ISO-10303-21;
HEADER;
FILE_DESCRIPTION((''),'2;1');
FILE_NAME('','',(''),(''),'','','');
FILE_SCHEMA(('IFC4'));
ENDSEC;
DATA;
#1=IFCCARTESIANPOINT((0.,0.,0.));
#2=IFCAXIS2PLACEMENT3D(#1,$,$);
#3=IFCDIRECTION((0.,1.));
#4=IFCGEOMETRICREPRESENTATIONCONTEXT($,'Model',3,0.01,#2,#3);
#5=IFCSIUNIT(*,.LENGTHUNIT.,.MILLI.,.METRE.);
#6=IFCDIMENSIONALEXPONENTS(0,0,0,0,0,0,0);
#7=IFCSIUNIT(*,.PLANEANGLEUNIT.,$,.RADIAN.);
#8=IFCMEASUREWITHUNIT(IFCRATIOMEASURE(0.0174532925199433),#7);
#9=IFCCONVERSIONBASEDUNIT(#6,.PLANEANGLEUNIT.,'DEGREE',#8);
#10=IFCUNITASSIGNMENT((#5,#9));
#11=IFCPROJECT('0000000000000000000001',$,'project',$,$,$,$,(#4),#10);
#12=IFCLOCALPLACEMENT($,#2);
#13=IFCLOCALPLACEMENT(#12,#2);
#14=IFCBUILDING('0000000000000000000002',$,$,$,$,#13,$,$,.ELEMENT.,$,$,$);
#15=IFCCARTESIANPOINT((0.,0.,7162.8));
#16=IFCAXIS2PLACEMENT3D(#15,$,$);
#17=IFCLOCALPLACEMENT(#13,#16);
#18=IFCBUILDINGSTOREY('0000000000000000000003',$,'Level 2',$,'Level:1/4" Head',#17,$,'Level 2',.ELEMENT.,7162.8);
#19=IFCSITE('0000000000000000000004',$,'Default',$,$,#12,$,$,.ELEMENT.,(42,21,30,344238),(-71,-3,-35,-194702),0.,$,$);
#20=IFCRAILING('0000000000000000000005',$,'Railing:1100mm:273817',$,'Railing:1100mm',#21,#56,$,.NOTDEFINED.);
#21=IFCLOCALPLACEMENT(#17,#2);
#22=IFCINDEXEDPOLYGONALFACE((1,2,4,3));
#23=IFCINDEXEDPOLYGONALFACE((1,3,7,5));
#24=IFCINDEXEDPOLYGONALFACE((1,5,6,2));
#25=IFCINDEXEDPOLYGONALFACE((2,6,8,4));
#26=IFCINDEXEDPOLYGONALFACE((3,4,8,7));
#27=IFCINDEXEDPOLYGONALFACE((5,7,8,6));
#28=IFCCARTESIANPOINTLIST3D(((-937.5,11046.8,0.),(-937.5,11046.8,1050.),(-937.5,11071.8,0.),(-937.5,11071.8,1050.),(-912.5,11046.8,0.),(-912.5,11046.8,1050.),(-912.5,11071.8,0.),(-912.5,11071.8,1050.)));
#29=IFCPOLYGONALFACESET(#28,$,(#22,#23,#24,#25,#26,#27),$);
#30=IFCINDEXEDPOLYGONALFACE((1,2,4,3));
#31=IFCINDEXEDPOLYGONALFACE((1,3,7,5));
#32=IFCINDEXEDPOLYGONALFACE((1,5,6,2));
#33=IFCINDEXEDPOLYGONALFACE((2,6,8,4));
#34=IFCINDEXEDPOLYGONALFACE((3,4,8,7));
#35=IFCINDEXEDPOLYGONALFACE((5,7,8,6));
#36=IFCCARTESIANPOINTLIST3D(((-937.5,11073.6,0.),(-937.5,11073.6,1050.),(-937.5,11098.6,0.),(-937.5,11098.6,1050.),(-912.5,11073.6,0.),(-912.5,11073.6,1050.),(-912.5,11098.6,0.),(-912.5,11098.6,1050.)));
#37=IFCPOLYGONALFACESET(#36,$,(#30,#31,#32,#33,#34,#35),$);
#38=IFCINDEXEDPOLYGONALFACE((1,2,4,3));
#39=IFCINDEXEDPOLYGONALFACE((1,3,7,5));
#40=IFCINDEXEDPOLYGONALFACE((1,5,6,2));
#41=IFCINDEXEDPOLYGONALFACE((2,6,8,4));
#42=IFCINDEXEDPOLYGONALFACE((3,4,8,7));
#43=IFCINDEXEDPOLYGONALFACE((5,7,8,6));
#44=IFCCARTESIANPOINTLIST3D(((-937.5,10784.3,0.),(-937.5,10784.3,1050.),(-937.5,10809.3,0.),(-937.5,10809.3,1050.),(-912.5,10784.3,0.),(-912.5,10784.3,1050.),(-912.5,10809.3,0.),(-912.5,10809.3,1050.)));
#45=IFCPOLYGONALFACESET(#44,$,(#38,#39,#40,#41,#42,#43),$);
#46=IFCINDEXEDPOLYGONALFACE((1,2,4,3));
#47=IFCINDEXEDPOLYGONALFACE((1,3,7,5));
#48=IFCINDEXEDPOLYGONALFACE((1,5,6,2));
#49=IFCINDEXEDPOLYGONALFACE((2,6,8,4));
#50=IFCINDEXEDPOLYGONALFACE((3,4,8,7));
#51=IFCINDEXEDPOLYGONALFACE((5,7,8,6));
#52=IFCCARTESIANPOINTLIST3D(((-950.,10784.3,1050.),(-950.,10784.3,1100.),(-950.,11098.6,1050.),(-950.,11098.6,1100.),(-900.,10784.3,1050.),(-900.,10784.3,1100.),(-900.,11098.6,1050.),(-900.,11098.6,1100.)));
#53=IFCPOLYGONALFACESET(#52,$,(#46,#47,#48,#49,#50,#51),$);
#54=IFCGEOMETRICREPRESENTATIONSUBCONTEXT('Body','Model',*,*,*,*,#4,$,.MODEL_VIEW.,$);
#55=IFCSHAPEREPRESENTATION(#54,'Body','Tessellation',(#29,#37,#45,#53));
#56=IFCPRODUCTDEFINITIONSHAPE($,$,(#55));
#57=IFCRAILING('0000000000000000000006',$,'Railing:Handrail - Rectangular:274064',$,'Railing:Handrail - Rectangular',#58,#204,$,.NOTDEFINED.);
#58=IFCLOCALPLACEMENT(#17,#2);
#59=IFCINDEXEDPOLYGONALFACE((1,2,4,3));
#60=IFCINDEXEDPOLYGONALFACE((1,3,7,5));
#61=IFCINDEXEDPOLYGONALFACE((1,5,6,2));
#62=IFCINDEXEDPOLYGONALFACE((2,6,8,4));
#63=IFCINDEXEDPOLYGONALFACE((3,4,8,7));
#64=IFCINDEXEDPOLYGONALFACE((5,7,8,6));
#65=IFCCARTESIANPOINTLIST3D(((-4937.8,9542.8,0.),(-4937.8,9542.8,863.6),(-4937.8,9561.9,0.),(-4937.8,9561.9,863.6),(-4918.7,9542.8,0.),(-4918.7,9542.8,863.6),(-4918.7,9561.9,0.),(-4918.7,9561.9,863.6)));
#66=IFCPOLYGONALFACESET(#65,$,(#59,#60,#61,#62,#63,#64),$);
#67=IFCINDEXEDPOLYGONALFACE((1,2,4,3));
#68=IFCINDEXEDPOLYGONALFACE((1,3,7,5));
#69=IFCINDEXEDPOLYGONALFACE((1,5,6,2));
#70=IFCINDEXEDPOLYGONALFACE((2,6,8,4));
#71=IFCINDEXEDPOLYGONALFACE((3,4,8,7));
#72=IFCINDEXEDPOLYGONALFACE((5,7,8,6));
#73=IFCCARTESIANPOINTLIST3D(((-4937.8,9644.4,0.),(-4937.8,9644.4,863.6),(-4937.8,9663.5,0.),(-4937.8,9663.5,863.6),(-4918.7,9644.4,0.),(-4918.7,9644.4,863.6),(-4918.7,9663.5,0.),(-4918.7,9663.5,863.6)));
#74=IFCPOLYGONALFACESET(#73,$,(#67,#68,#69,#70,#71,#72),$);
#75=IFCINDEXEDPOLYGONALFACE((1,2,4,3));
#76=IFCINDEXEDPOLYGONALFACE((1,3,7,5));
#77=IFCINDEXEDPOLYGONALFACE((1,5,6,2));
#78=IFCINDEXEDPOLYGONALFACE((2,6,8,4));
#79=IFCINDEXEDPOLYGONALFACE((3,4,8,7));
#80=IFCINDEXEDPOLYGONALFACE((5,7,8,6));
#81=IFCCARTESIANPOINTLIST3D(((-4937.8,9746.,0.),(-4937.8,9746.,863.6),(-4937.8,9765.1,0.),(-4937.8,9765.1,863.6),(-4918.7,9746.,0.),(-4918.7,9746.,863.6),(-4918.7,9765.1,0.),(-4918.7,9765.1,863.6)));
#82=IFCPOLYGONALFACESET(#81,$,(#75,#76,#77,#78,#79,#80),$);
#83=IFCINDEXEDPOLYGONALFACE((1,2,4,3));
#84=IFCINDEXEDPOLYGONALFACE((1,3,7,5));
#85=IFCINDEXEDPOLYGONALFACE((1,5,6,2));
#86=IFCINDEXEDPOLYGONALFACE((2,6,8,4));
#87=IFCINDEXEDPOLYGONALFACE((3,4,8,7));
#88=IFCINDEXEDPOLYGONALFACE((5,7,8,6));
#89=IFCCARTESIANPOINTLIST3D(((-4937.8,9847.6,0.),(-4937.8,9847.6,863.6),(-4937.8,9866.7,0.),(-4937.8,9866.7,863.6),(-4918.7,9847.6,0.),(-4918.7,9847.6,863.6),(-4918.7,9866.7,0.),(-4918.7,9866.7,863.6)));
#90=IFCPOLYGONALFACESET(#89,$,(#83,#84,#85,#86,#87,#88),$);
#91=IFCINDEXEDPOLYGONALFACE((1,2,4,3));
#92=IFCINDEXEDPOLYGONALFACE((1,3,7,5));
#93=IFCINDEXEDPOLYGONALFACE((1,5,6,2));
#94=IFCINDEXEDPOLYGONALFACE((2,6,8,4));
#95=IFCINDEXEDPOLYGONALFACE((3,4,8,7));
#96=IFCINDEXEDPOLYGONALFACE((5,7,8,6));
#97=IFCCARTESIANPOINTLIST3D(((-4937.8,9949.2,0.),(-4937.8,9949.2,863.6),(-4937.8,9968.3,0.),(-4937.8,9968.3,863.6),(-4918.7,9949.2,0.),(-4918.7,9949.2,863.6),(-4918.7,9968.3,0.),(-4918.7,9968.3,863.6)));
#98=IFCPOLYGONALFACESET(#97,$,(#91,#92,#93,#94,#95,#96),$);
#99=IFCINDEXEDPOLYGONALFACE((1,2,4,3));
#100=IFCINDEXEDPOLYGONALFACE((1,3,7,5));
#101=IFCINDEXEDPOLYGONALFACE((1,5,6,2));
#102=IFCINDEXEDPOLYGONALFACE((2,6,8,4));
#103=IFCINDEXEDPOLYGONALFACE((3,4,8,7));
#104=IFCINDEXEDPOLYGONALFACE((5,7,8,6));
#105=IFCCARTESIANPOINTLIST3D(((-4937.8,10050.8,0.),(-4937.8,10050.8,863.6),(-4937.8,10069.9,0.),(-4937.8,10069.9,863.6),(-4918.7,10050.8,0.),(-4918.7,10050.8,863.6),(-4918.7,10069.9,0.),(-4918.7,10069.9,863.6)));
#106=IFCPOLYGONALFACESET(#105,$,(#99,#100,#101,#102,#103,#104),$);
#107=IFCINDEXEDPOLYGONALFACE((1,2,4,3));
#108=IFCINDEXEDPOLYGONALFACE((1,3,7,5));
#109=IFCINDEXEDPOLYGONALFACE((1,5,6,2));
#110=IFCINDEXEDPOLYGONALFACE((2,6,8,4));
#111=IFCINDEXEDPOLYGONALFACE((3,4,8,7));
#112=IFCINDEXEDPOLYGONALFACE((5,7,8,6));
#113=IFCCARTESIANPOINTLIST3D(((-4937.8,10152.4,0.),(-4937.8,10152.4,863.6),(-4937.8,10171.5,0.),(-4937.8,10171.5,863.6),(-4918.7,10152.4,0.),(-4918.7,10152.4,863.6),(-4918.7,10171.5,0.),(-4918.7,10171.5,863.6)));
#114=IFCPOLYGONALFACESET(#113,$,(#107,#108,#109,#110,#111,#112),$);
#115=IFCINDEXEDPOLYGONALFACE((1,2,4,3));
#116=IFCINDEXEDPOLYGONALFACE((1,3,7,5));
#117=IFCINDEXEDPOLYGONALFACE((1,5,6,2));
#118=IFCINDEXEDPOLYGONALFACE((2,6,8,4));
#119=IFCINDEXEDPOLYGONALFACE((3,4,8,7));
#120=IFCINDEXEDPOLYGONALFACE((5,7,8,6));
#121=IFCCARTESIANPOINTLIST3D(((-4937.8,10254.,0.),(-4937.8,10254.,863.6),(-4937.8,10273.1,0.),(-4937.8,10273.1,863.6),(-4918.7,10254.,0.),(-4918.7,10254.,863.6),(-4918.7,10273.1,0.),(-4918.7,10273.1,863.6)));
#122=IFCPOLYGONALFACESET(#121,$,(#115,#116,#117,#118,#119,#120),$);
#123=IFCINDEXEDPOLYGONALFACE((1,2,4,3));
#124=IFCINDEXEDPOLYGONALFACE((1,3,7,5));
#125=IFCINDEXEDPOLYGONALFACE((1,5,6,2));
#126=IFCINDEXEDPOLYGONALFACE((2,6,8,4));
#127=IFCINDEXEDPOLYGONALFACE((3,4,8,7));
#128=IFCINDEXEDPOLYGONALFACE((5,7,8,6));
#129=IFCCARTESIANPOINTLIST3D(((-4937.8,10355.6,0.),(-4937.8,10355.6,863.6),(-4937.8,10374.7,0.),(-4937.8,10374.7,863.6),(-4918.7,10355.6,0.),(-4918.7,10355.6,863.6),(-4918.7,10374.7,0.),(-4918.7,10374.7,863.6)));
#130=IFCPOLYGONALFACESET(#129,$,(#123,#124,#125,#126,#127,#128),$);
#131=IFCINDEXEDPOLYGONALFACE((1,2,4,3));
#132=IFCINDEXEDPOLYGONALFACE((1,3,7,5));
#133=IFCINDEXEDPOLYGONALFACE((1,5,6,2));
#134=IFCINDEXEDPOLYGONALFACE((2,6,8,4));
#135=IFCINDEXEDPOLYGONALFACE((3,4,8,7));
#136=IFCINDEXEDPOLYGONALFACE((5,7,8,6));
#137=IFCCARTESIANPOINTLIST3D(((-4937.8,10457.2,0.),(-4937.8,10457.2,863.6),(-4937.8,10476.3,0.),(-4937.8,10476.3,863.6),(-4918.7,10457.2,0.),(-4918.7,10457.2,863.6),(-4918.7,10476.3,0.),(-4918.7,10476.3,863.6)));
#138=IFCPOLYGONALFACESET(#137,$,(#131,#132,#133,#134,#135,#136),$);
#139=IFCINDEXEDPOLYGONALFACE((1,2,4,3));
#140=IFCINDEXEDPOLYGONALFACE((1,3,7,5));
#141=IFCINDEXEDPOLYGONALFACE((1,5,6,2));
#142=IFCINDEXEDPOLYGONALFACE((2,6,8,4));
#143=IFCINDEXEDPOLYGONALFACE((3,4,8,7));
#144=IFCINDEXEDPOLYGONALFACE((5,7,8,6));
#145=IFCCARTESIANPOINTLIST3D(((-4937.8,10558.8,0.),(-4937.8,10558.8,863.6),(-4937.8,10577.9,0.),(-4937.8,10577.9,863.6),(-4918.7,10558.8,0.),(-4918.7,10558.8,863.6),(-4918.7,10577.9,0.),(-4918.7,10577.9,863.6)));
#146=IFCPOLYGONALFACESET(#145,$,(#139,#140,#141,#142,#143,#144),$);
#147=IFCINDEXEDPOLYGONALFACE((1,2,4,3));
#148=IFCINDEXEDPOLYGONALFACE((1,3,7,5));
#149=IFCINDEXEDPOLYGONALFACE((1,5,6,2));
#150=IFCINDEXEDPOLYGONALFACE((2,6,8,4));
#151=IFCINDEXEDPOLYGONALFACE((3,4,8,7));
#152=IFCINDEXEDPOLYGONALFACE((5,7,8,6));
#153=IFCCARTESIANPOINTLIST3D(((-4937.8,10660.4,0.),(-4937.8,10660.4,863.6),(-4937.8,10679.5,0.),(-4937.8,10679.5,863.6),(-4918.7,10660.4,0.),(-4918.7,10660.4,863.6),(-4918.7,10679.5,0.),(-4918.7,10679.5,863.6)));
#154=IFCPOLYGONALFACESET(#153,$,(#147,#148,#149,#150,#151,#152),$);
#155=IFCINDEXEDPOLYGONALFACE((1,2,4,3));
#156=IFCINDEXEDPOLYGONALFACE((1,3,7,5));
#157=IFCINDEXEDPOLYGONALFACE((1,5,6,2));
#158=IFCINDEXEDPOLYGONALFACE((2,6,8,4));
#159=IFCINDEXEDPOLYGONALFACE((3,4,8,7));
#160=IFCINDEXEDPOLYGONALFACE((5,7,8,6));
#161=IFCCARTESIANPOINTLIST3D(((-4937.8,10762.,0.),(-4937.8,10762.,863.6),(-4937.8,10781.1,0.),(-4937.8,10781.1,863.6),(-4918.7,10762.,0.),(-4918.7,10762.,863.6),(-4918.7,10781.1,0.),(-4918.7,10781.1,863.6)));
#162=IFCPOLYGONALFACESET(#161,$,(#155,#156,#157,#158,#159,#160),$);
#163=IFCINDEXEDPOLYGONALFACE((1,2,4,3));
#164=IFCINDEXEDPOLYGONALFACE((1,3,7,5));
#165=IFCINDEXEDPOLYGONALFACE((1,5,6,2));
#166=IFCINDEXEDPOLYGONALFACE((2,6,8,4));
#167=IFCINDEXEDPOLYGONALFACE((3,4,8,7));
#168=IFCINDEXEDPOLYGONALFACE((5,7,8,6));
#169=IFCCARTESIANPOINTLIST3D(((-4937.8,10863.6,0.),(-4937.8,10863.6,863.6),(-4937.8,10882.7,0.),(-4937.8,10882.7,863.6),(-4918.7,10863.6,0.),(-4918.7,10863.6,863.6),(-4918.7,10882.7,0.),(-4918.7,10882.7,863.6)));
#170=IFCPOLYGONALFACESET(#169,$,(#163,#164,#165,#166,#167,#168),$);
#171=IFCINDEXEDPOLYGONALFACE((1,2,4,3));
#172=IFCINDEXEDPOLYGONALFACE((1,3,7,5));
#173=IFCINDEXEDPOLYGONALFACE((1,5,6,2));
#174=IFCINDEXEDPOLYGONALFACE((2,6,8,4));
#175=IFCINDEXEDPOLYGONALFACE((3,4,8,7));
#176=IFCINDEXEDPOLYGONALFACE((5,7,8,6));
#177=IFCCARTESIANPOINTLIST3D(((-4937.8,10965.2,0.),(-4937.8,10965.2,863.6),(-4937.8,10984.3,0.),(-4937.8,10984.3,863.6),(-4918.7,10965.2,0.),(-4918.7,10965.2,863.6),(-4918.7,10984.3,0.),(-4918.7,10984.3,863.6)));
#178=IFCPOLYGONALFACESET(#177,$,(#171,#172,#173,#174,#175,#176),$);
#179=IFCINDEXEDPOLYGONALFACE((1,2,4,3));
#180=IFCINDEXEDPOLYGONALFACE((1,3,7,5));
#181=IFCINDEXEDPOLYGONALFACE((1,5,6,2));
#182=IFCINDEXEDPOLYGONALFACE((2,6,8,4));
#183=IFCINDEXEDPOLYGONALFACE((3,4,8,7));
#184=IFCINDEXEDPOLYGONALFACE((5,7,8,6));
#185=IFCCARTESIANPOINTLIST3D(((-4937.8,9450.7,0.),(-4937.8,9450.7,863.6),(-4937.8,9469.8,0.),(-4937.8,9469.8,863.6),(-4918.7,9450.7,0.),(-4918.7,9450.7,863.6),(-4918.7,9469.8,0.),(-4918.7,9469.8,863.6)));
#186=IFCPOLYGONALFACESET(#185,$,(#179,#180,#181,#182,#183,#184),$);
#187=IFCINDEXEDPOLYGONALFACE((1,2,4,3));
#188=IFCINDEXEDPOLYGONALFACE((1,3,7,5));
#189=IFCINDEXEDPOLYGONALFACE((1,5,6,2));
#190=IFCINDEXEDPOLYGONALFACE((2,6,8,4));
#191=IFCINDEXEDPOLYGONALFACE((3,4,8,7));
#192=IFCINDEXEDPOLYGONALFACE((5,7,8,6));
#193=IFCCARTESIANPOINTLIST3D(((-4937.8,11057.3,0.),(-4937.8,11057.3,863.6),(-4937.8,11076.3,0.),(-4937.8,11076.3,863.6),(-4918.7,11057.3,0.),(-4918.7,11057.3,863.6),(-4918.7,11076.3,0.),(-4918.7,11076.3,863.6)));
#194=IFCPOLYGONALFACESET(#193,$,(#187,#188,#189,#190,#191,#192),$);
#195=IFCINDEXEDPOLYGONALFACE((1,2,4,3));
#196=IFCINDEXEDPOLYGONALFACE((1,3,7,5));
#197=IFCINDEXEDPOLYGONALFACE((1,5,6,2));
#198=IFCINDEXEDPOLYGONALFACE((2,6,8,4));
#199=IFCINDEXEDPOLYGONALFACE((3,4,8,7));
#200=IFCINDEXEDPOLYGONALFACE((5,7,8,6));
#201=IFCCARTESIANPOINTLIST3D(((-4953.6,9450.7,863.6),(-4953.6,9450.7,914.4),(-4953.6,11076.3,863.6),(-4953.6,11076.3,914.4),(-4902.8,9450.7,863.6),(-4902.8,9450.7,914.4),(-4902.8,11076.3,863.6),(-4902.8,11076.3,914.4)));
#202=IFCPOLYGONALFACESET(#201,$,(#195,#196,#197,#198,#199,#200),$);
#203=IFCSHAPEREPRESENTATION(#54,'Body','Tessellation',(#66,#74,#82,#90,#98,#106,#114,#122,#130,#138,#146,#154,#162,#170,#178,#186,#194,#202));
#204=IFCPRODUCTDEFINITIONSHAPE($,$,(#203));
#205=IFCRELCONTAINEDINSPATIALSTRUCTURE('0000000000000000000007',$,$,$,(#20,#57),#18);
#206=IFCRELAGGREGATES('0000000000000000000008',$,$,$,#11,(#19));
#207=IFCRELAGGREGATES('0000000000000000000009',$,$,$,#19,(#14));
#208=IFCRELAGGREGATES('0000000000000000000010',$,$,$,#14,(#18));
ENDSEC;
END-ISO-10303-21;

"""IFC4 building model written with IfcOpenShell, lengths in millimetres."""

from ifc_helpers import new_model, entity, si_unit, converted_unit, direction, frame, origin, place, context, subcontext, project, spatial, indexed_curve, outline, extrude, element, save


model = new_model("IFC4")

# Units and contexts
model_context = context("Model", 3, precision=0.01, world=origin(), true_north=direction((0.0, 1.0)))
body_context = subcontext(model_context, "Body", "Model", "MODEL_VIEW")
ifc_project = project(units=[si_unit("LENGTHUNIT", "METRE", prefix="MILLI"), converted_unit("PLANEANGLEUNIT", "DEGREE", entity("IfcRatioMeasure", 0.0174532925199433), si_unit("PLANEANGLEUNIT", "RADIAN"), dimensions=[0, 0, 0, 0, 0, 0, 0])], contexts=[model_context])

# Site, building, storey
site_placement = place(None, origin())
site = spatial("IfcSite", under=ifc_project, at=site_placement, Name="Default", CompositionType="ELEMENT", RefLatitude=(42, 21, 30, 344238), RefLongitude=(-71, -3, -35, -194702), RefElevation=0.0)
building_placement = place(site_placement, origin())
building = spatial("IfcBuilding", under=site, at=building_placement, CompositionType="ELEMENT")
storey_placement = place(building_placement, frame((0.0, 0.0, 7162.8)))
storey = spatial("IfcBuildingStorey", under=building, at=storey_placement, Name="Level 2", ObjectType="Level:1/4\" Head", LongName="Level 2", CompositionType="ELEMENT", Elevation=7162.8)

# Railings
railing_1_placement = place(storey_placement, origin())
element("IfcRailing", 1, at=railing_1_placement, inside=storey, Name="Railing:1100mm:273817", ObjectType="Railing:1100mm", PredefinedType="NOTDEFINED", context=body_context, shape_type="SweptSolid", body=[
    extrude(outline(indexed_curve([(-12.5, -12.5), (12.5, -12.5), (12.5, 12.5), (-12.5, 12.5), (-12.5, -12.5)], self_intersect=False)), frame((-925.0, 11059.3, 0.0), z_axis=(0.0, 0.0, 1.0), x_axis=(0.0, 1.0, 0.0)), (0.0, 0.0, 1.0), 1050.0),
    extrude(outline(indexed_curve([(-12.5, -12.5), (12.5, -12.5), (12.5, 12.5), (-12.5, 12.5), (-12.5, -12.5)], self_intersect=False)), frame((-925.0, 11086.1, 0.0), z_axis=(0.0, 0.0, 1.0), x_axis=(0.0, 1.0, 0.0)), (0.0, 0.0, 1.0), 1050.0),
    extrude(outline(indexed_curve([(-12.5, -12.5), (12.5, -12.5), (12.5, 12.5), (-12.5, 12.5), (-12.5, -12.5)], self_intersect=False)), frame((-925.0, 10796.8, 0.0), z_axis=(0.0, 0.0, 1.0), x_axis=(0.0, 1.0, 0.0)), (0.0, 0.0, 1.0), 1050.0),
    extrude(outline(indexed_curve([(-157.2, -25.0), (157.2, -25.0), (157.2, 25.0), (-157.2, 25.0), (-157.2, -25.0)], self_intersect=False)), frame((-925.0, 10941.5, 1050.0), z_axis=(0.0, 0.0, 1.0), x_axis=(0.0, 1.0, 0.0)), (0.0, 0.0, 1.0), 50.0),
])
railing_2_placement = place(storey_placement, origin())
element("IfcRailing", 2, at=railing_2_placement, inside=storey, Name="Railing:Handrail - Rectangular:274064", ObjectType="Railing:Handrail - Rectangular", PredefinedType="NOTDEFINED", context=body_context, shape_type="SweptSolid", body=[
    extrude(outline(indexed_curve([(-9.5, -9.5), (9.5, -9.5), (9.5, 9.5), (-9.5, 9.5), (-9.5, -9.5)], self_intersect=False)), frame((-4928.2, 9552.3, 0.0), z_axis=(0.0, 0.0, 1.0), x_axis=(0.0, -1.0, 0.0)), (0.0, 0.0, 1.0), 863.6),
    extrude(outline(indexed_curve([(-9.5, -9.5), (9.5, -9.5), (9.5, 9.5), (-9.5, 9.5), (-9.5, -9.5)], self_intersect=False)), frame((-4928.2, 9653.9, 0.0), z_axis=(0.0, 0.0, 1.0), x_axis=(0.0, -1.0, 0.0)), (0.0, 0.0, 1.0), 863.6),
    extrude(outline(indexed_curve([(-9.5, -9.5), (9.5, -9.5), (9.5, 9.5), (-9.5, 9.5), (-9.5, -9.5)], self_intersect=False)), frame((-4928.2, 9755.5, 0.0), z_axis=(0.0, 0.0, 1.0), x_axis=(0.0, -1.0, 0.0)), (0.0, 0.0, 1.0), 863.6),
    extrude(outline(indexed_curve([(-9.5, -9.5), (9.5, -9.5), (9.5, 9.5), (-9.5, 9.5), (-9.5, -9.5)], self_intersect=False)), frame((-4928.2, 9857.1, 0.0), z_axis=(0.0, 0.0, 1.0), x_axis=(0.0, -1.0, 0.0)), (0.0, 0.0, 1.0), 863.6),
    extrude(outline(indexed_curve([(-9.5, -9.5), (9.5, -9.5), (9.5, 9.5), (-9.5, 9.5), (-9.5, -9.5)], self_intersect=False)), frame((-4928.2, 9958.7, 0.0), z_axis=(0.0, 0.0, 1.0), x_axis=(0.0, -1.0, 0.0)), (0.0, 0.0, 1.0), 863.6),
    extrude(outline(indexed_curve([(-9.5, -9.5), (9.5, -9.5), (9.5, 9.5), (-9.5, 9.5), (-9.5, -9.5)], self_intersect=False)), frame((-4928.2, 10060.3, 0.0), z_axis=(0.0, 0.0, 1.0), x_axis=(0.0, -1.0, 0.0)), (0.0, 0.0, 1.0), 863.6),
    extrude(outline(indexed_curve([(-9.5, -9.5), (9.5, -9.5), (9.5, 9.5), (-9.5, 9.5), (-9.5, -9.5)], self_intersect=False)), frame((-4928.2, 10161.9, 0.0), z_axis=(0.0, 0.0, 1.0), x_axis=(0.0, -1.0, 0.0)), (0.0, 0.0, 1.0), 863.6),
    extrude(outline(indexed_curve([(-9.5, -9.5), (9.5, -9.5), (9.5, 9.5), (-9.5, 9.5), (-9.5, -9.5)], self_intersect=False)), frame((-4928.2, 10263.5, 0.0), z_axis=(0.0, 0.0, 1.0), x_axis=(0.0, -1.0, 0.0)), (0.0, 0.0, 1.0), 863.6),
    extrude(outline(indexed_curve([(-9.5, -9.5), (9.5, -9.5), (9.5, 9.5), (-9.5, 9.5), (-9.5, -9.5)], self_intersect=False)), frame((-4928.2, 10365.1, 0.0), z_axis=(0.0, 0.0, 1.0), x_axis=(0.0, -1.0, 0.0)), (0.0, 0.0, 1.0), 863.6),
    extrude(outline(indexed_curve([(-9.5, -9.5), (9.5, -9.5), (9.5, 9.5), (-9.5, 9.5), (-9.5, -9.5)], self_intersect=False)), frame((-4928.2, 10466.7, 0.0), z_axis=(0.0, 0.0, 1.0), x_axis=(0.0, -1.0, 0.0)), (0.0, 0.0, 1.0), 863.6),
    extrude(outline(indexed_curve([(-9.5, -9.5), (9.5, -9.5), (9.5, 9.5), (-9.5, 9.5), (-9.5, -9.5)], self_intersect=False)), frame((-4928.2, 10568.3, 0.0), z_axis=(0.0, 0.0, 1.0), x_axis=(0.0, -1.0, 0.0)), (0.0, 0.0, 1.0), 863.6),
    extrude(outline(indexed_curve([(-9.5, -9.5), (9.5, -9.5), (9.5, 9.5), (-9.5, 9.5), (-9.5, -9.5)], self_intersect=False)), frame((-4928.2, 10669.9, 0.0), z_axis=(0.0, 0.0, 1.0), x_axis=(0.0, -1.0, 0.0)), (0.0, 0.0, 1.0), 863.6),
    extrude(outline(indexed_curve([(-9.5, -9.5), (9.5, -9.5), (9.5, 9.5), (-9.5, 9.5), (-9.5, -9.5)], self_intersect=False)), frame((-4928.2, 10771.5, 0.0), z_axis=(0.0, 0.0, 1.0), x_axis=(0.0, -1.0, 0.0)), (0.0, 0.0, 1.0), 863.6),
    extrude(outline(indexed_curve([(-9.5, -9.5), (9.5, -9.5), (9.5, 9.5), (-9.5, 9.5), (-9.5, -9.5)], self_intersect=False)), frame((-4928.2, 10873.1, 0.0), z_axis=(0.0, 0.0, 1.0), x_axis=(0.0, -1.0, 0.0)), (0.0, 0.0, 1.0), 863.6),
    extrude(outline(indexed_curve([(-9.5, -9.5), (9.5, -9.5), (9.5, 9.5), (-9.5, 9.5), (-9.5, -9.5)], self_intersect=False)), frame((-4928.2, 10974.7, 0.0), z_axis=(0.0, 0.0, 1.0), x_axis=(0.0, -1.0, 0.0)), (0.0, 0.0, 1.0), 863.6),
    extrude(outline(indexed_curve([(-9.5, -9.5), (9.5, -9.5), (9.5, 9.5), (-9.5, 9.5), (-9.5, -9.5)], self_intersect=False)), frame((-4928.2, 9460.3, 0.0), z_axis=(0.0, 0.0, 1.0), x_axis=(0.0, -1.0, 0.0)), (0.0, 0.0, 1.0), 863.6),
    extrude(outline(indexed_curve([(-9.5, -9.5), (9.5, -9.5), (9.5, 9.5), (-9.5, 9.5), (-9.5, -9.5)], self_intersect=False)), frame((-4928.2, 11066.8, 0.0), z_axis=(0.0, 0.0, 1.0), x_axis=(0.0, -1.0, 0.0)), (0.0, 0.0, 1.0), 863.6),
    extrude(outline(indexed_curve([(-812.8, -25.4), (812.8, -25.4), (812.8, 25.4), (-812.8, 25.4), (-812.8, -25.4)], self_intersect=False)), frame((-4928.2, 10263.5, 863.6), z_axis=(0.0, 0.0, 1.0), x_axis=(0.0, -1.0, 0.0)), (0.0, 0.0, 1.0), 50.8),
])

save(model, "model.ifc")
